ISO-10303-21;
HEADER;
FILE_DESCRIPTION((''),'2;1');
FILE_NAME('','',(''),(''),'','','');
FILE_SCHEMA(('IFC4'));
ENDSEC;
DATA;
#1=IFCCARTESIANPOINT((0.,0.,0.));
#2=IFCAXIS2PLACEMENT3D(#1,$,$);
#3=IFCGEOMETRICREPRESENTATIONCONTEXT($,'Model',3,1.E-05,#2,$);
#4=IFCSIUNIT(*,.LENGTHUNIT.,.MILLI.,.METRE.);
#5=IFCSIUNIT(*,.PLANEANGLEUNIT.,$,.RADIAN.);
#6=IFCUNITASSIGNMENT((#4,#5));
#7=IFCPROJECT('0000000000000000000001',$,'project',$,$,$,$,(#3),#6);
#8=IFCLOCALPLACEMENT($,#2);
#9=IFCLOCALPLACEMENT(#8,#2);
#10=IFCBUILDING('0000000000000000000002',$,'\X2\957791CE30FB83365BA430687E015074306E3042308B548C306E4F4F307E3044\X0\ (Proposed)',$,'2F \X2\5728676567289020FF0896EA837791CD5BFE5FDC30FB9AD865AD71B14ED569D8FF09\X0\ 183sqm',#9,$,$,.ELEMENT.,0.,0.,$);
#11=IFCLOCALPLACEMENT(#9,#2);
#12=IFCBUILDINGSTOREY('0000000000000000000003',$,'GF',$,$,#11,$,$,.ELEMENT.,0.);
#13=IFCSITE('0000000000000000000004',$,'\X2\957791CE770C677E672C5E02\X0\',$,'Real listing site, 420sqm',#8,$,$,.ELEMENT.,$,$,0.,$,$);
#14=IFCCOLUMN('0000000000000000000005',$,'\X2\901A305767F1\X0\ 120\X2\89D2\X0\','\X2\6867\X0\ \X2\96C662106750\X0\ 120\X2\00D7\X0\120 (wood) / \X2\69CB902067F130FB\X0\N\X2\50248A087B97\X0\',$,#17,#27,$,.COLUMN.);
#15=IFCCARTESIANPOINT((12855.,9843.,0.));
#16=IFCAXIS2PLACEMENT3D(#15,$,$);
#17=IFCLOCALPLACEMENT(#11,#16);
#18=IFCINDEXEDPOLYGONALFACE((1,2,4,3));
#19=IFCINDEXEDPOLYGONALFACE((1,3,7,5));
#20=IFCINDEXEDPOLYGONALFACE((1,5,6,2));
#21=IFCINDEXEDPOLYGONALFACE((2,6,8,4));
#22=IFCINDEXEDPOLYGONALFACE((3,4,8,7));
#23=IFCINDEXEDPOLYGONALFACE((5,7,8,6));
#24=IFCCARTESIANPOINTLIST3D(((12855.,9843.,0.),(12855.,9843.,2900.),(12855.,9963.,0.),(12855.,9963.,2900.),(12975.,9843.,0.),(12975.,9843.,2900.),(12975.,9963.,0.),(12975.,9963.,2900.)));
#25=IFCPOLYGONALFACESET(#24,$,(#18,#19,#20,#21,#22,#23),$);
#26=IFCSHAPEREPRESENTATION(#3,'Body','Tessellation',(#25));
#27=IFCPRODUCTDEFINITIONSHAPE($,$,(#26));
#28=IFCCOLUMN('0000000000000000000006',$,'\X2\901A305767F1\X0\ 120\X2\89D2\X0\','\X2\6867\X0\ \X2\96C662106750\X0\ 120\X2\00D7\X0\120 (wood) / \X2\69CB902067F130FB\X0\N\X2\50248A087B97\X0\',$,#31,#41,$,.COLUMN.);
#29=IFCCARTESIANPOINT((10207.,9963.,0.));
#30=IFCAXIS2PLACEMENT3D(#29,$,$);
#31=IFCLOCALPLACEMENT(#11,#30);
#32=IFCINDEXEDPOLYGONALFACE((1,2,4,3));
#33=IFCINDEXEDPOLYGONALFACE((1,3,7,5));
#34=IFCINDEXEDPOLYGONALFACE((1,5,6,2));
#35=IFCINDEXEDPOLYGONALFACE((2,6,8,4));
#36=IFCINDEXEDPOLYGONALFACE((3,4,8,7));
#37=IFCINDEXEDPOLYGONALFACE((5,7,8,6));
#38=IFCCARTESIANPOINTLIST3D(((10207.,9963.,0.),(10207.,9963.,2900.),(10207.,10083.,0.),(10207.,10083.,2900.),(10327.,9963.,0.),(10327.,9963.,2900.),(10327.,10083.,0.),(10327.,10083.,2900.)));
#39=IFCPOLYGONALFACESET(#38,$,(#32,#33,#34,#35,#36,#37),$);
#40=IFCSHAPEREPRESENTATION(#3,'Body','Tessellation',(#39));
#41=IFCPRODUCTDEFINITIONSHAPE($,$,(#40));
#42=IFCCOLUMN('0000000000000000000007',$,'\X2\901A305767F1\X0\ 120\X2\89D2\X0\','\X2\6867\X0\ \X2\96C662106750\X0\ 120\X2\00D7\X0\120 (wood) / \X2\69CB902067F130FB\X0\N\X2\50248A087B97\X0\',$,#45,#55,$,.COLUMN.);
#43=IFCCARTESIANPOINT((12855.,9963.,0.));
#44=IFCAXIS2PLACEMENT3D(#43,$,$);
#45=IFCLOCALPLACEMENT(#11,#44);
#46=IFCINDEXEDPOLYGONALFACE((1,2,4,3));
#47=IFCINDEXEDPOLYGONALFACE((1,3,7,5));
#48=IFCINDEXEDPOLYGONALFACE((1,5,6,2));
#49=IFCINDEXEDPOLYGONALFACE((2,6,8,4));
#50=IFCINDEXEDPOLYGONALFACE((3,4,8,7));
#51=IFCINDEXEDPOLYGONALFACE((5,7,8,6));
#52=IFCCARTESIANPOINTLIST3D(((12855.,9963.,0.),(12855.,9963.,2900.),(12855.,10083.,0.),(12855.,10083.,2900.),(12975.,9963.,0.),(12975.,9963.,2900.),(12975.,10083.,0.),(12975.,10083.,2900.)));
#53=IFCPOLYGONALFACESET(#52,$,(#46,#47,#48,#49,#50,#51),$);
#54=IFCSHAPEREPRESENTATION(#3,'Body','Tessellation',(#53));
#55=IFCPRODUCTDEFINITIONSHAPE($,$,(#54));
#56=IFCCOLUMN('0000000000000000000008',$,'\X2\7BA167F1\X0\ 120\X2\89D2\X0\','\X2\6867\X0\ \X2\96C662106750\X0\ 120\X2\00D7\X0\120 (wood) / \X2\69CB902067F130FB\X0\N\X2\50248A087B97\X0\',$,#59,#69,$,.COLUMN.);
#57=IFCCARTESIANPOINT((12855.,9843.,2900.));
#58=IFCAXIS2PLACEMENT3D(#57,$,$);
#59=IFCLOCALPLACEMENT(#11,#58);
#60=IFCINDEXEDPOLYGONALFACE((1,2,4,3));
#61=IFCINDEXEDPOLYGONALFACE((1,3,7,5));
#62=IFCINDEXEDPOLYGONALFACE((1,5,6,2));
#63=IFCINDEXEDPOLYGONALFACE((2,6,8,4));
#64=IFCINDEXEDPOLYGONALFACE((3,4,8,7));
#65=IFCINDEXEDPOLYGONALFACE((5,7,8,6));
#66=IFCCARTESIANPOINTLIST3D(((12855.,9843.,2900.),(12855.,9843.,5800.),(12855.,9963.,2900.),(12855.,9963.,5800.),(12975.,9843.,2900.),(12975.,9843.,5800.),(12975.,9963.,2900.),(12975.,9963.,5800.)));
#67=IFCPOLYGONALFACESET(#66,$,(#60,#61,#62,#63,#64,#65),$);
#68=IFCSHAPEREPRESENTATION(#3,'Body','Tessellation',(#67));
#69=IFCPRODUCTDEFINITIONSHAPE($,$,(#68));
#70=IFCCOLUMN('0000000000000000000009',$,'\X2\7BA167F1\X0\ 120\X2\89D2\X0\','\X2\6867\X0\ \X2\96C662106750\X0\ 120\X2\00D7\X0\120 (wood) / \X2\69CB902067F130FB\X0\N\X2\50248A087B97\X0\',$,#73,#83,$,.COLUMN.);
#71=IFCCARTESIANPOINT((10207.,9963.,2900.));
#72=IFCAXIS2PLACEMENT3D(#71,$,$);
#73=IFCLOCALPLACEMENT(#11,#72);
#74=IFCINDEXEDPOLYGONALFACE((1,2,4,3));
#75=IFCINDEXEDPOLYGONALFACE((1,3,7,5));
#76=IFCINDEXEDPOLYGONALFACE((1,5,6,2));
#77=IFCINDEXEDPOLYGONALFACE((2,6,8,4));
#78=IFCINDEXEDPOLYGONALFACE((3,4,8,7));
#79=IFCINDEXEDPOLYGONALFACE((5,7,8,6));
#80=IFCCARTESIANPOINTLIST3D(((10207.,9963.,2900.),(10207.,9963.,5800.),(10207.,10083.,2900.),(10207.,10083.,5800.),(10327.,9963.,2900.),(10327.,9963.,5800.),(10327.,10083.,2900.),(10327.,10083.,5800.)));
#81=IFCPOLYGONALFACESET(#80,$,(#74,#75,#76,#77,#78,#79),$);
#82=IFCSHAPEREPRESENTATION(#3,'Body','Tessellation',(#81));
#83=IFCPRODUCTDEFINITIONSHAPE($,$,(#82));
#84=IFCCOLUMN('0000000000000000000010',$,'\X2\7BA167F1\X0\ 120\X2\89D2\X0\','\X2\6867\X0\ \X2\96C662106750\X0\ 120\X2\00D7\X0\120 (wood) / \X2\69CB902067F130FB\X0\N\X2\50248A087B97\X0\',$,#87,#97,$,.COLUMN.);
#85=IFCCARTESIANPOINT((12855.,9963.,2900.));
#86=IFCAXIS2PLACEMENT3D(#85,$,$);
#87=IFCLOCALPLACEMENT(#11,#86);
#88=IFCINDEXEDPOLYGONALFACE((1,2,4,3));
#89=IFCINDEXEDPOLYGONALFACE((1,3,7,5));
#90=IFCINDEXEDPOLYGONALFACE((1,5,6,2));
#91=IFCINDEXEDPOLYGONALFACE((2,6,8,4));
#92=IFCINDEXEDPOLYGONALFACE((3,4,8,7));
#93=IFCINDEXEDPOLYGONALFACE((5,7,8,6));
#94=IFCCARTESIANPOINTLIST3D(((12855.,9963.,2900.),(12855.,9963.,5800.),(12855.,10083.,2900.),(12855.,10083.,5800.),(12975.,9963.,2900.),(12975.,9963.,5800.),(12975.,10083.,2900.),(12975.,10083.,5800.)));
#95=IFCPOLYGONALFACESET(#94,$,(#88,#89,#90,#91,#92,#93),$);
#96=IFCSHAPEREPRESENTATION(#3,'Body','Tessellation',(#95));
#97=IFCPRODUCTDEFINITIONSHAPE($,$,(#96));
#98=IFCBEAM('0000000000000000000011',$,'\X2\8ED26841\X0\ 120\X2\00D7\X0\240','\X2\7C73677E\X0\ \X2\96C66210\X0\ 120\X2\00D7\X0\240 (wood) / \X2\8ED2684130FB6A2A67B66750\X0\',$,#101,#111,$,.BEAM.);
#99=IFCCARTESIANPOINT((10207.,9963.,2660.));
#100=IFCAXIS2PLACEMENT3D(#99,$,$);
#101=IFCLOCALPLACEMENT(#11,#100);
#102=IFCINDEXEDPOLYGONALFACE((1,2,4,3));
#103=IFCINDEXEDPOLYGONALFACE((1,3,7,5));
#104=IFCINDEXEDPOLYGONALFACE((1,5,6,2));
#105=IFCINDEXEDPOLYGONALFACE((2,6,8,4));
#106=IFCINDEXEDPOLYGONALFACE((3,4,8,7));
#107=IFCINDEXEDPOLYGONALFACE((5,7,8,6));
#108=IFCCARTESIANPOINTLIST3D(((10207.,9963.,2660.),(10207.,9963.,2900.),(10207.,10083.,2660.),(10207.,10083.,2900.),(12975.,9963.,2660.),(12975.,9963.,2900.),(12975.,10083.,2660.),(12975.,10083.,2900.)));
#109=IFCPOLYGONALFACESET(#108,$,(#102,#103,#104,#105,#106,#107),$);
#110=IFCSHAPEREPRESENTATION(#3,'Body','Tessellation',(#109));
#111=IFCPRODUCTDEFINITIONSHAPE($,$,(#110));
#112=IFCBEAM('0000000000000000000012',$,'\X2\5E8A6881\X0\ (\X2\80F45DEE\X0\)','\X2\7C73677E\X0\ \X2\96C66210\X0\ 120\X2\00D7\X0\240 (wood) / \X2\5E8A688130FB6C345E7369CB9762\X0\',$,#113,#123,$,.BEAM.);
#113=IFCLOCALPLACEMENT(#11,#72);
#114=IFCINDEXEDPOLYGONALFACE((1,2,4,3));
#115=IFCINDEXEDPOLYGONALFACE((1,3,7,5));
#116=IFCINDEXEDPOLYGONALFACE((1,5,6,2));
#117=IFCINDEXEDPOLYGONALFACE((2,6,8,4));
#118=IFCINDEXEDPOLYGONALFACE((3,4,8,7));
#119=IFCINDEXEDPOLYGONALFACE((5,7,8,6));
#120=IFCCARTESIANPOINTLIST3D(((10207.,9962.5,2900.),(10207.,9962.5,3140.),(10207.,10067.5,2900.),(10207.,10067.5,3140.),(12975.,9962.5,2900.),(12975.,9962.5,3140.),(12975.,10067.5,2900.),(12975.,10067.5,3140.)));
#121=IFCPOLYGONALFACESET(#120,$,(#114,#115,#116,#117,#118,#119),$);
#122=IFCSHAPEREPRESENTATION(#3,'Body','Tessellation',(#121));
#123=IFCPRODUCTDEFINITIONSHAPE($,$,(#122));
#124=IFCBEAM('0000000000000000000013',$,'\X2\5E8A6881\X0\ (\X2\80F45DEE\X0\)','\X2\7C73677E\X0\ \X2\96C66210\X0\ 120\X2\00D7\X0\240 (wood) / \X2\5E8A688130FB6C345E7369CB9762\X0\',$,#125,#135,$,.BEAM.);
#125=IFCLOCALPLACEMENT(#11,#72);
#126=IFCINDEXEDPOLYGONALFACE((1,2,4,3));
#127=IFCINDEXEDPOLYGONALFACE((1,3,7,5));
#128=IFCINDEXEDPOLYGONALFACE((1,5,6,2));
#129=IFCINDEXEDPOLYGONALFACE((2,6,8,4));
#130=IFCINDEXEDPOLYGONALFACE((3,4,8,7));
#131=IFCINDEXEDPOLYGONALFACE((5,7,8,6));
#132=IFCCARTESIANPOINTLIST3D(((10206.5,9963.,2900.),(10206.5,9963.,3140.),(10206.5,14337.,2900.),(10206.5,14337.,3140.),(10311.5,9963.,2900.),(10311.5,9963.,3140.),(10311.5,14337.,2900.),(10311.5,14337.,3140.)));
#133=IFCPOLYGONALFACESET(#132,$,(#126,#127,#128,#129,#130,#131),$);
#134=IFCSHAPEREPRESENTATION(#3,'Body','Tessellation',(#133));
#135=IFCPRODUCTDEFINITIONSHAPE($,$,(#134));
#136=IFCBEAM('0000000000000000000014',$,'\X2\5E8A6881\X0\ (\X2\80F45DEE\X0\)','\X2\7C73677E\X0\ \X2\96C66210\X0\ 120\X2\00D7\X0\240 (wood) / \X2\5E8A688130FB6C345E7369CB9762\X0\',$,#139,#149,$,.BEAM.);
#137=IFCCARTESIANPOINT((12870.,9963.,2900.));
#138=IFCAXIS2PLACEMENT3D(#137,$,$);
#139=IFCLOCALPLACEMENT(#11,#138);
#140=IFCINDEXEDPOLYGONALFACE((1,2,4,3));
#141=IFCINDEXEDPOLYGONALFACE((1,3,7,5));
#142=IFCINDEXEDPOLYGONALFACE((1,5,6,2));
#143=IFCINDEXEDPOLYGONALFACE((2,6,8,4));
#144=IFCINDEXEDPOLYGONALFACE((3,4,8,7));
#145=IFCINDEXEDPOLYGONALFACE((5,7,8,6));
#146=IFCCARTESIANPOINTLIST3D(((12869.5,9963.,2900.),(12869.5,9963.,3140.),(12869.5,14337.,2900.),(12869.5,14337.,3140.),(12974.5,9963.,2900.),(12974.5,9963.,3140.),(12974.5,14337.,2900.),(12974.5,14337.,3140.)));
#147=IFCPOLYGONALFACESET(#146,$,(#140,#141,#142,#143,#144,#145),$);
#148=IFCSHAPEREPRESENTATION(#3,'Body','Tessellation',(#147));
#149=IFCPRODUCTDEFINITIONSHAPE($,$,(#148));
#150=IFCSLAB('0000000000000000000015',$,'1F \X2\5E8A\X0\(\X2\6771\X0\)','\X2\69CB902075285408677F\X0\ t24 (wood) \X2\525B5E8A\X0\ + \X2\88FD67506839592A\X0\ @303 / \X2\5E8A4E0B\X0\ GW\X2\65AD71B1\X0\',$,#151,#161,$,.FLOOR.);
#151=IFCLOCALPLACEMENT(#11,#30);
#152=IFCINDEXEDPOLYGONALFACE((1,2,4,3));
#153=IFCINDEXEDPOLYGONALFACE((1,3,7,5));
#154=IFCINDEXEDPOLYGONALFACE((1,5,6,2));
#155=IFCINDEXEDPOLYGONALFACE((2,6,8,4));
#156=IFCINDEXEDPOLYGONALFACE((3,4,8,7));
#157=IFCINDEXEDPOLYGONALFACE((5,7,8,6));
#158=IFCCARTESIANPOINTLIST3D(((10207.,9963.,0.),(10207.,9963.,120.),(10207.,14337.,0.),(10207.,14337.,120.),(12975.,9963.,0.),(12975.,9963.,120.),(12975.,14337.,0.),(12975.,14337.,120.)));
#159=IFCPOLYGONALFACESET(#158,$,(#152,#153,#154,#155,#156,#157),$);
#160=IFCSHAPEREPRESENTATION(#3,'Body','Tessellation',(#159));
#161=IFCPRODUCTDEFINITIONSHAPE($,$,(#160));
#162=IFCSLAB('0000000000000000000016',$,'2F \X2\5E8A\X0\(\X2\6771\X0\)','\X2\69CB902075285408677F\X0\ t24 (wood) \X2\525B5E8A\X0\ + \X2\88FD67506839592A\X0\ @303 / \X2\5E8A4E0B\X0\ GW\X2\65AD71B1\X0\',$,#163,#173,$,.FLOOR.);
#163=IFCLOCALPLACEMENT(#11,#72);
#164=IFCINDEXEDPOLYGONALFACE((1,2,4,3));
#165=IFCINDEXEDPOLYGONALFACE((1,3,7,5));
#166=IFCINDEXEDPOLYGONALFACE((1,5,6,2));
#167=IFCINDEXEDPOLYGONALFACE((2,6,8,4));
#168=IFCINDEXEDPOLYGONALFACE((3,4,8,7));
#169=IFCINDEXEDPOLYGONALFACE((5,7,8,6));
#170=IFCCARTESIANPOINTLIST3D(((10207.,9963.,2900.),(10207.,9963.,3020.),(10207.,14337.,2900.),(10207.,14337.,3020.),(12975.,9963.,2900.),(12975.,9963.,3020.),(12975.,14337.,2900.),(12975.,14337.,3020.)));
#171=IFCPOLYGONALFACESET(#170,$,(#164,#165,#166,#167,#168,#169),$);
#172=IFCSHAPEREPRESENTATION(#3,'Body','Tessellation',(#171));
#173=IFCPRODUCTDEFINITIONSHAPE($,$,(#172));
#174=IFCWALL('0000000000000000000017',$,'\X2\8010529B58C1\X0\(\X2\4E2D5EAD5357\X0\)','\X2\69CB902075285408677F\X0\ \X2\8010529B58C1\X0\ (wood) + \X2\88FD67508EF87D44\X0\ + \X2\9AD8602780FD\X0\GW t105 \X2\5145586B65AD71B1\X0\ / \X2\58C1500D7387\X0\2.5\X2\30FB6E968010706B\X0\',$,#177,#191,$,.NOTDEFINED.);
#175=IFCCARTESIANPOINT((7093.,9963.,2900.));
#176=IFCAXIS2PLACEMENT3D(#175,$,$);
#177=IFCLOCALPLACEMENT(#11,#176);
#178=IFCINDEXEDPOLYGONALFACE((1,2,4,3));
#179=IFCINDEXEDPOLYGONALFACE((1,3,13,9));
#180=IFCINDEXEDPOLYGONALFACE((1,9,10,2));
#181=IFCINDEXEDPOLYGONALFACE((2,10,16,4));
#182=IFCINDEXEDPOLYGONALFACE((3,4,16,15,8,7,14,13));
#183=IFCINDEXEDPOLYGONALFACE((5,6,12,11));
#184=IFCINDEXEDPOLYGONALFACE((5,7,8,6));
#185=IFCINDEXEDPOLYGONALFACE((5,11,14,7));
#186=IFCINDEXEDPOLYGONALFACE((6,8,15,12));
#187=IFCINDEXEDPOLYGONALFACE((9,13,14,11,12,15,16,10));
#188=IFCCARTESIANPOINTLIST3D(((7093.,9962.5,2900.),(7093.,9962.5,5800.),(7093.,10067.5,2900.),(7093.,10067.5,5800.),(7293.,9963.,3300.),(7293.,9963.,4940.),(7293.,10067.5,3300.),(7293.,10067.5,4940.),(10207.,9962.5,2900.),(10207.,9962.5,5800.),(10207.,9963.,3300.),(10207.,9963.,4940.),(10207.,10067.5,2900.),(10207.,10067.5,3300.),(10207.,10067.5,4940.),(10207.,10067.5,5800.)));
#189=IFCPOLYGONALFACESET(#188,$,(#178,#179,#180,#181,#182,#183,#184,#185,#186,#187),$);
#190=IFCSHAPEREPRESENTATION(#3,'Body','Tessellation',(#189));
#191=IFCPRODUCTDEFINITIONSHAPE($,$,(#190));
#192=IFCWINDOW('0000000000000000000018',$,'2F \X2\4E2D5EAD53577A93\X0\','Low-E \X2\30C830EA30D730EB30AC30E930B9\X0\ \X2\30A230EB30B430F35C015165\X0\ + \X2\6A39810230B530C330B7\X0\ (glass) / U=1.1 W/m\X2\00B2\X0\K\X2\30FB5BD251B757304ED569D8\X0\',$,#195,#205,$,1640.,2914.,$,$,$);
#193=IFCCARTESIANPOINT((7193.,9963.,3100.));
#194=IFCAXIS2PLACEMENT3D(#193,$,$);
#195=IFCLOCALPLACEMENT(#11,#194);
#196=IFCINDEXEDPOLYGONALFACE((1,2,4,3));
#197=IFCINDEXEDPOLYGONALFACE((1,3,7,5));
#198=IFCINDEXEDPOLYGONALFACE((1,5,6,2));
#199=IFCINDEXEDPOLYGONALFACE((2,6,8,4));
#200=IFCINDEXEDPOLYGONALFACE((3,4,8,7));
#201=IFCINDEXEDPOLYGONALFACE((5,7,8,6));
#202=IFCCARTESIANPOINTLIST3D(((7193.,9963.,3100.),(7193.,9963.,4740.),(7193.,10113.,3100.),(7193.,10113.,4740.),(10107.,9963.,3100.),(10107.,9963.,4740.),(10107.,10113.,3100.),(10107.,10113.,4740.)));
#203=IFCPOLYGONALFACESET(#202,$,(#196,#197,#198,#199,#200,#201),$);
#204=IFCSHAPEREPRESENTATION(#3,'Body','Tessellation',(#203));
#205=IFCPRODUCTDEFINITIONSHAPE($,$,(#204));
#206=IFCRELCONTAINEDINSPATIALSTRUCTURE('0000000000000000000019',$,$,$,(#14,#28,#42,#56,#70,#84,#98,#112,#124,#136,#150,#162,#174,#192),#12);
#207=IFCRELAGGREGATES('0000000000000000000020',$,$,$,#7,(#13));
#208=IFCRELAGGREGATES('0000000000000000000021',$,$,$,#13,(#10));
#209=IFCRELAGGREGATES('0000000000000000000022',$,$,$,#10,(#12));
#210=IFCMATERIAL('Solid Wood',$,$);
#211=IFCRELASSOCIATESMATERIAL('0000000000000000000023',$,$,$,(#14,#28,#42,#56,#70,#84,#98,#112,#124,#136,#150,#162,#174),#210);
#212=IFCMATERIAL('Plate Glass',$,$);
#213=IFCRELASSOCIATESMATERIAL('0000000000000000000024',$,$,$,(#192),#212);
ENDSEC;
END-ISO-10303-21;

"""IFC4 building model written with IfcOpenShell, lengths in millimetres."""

from ifc_helpers import new_model, si_unit, frame, frame_2d, origin, place, context, project, spatial, rectangle, extrude, material, element, fill, save


model = new_model("IFC4")

# Units and contexts
model_context = context("Model", 3, precision=1e-05, world=origin())
ifc_project = project(units=[si_unit("LENGTHUNIT", "METRE", prefix="MILLI"), si_unit("PLANEANGLEUNIT", "RADIAN")], contexts=[model_context])

# Site, building, storey
site_placement = place(None, origin())
site = spatial("IfcSite", under=ifc_project, at=site_placement, Name="長野県松本市", ObjectType="Real listing site, 420sqm", CompositionType="ELEMENT", RefElevation=0.0)
building_placement = place(site_placement, origin())
building = spatial("IfcBuilding", under=site, at=building_placement, Name="長野・茶室と縁側のある和の住まい (Proposed)", ObjectType="2F 在来木造（雪荷重対応・高断熱仕様） 183sqm", CompositionType="ELEMENT", ElevationOfRefHeight=0.0, ElevationOfTerrain=0.0)
storey_placement = place(building_placement, origin())
storey = spatial("IfcBuildingStorey", under=building, at=storey_placement, Name="GF", CompositionType="ELEMENT", Elevation=0.0)

# Columns
ifc_material_1 = material(Name="Solid Wood")
column_1_placement = place(storey_placement, frame((12855.0, 9843.0, 0.0)))
element("IfcColumn", 1, at=column_1_placement, inside=storey, material=ifc_material_1, Name="通し柱 120角", Description="桧 集成材 120×120 (wood) / 構造柱・N値計算", PredefinedType="COLUMN", context=model_context, shape_type="SweptSolid", body=[
    extrude(rectangle(XDim=120.0, YDim=120.0, at=frame_2d((60.0, 60.0))), frame((12855.0, 9843.0, 0.0)), (0.0, 0.0, 1.0), 2900.0),
])
column_2_placement = place(storey_placement, frame((10207.0, 9963.0, 0.0)))
element("IfcColumn", 2, at=column_2_placement, inside=storey, material=ifc_material_1, Name="通し柱 120角", Description="桧 集成材 120×120 (wood) / 構造柱・N値計算", PredefinedType="COLUMN", context=model_context, shape_type="SweptSolid", body=[
    extrude(rectangle(XDim=120.0, YDim=120.0, at=frame_2d((60.0, 60.0))), frame((10207.0, 9963.0, 0.0)), (0.0, 0.0, 1.0), 2900.0),
])
column_3_placement = place(storey_placement, frame((12855.0, 9963.0, 0.0)))
element("IfcColumn", 3, at=column_3_placement, inside=storey, material=ifc_material_1, Name="通し柱 120角", Description="桧 集成材 120×120 (wood) / 構造柱・N値計算", PredefinedType="COLUMN", context=model_context, shape_type="SweptSolid", body=[
    extrude(rectangle(XDim=120.0, YDim=120.0, at=frame_2d((60.0, 60.0))), frame((12855.0, 9963.0, 0.0)), (0.0, 0.0, 1.0), 2900.0),
])
column_4_placement = place(storey_placement, frame((12855.0, 9843.0, 2900.0)))
element("IfcColumn", 4, at=column_4_placement, inside=storey, material=ifc_material_1, Name="管柱 120角", Description="桧 集成材 120×120 (wood) / 構造柱・N値計算", PredefinedType="COLUMN", context=model_context, shape_type="SweptSolid", body=[
    extrude(rectangle(XDim=120.0, YDim=120.0, at=frame_2d((60.0, 60.0))), frame((12855.0, 9843.0, 2900.0)), (0.0, 0.0, 1.0), 2900.0),
])
column_5_placement = place(storey_placement, frame((10207.0, 9963.0, 2900.0)))
element("IfcColumn", 5, at=column_5_placement, inside=storey, material=ifc_material_1, Name="管柱 120角", Description="桧 集成材 120×120 (wood) / 構造柱・N値計算", PredefinedType="COLUMN", context=model_context, shape_type="SweptSolid", body=[
    extrude(rectangle(XDim=120.0, YDim=120.0, at=frame_2d((60.0, 60.0))), frame((10207.0, 9963.0, 2900.0)), (0.0, 0.0, 1.0), 2900.0),
])
column_6_placement = place(storey_placement, frame((12855.0, 9963.0, 2900.0)))
element("IfcColumn", 6, at=column_6_placement, inside=storey, material=ifc_material_1, Name="管柱 120角", Description="桧 集成材 120×120 (wood) / 構造柱・N値計算", PredefinedType="COLUMN", context=model_context, shape_type="SweptSolid", body=[
    extrude(rectangle(XDim=120.0, YDim=120.0, at=frame_2d((60.0, 60.0))), frame((12855.0, 9963.0, 2900.0)), (0.0, 0.0, 1.0), 2900.0),
])

# Beams
beam_1_placement = place(storey_placement, frame((10207.0, 9963.0, 2660.0)))
element("IfcBeam", 7, at=beam_1_placement, inside=storey, material=ifc_material_1, Name="軒桁 120×240", Description="米松 集成 120×240 (wood) / 軒桁・横架材", PredefinedType="BEAM", context=model_context, shape_type="SweptSolid", body=[
    extrude(rectangle(XDim=2768.0, YDim=120.0, at=frame_2d((1384.0, 60.0))), frame((10207.0, 9963.0, 2660.0)), (0.0, 0.0, 1.0), 240.0),
])
beam_2_placement = place(storey_placement, frame((10207.0, 9963.0, 2900.0)))
element("IfcBeam", 8, at=beam_2_placement, inside=storey, material=ifc_material_1, Name="床梁 (胴差)", Description="米松 集成 120×240 (wood) / 床梁・水平構面", PredefinedType="BEAM", context=model_context, shape_type="SweptSolid", body=[
    extrude(rectangle(XDim=2768.0, YDim=105.0, at=frame_2d((1384.0, 52.0))), frame((10207.0, 9963.0, 2900.0)), (0.0, 0.0, 1.0), 240.0),
])
beam_3_placement = place(storey_placement, frame((10207.0, 9963.0, 2900.0)))
element("IfcBeam", 9, at=beam_3_placement, inside=storey, material=ifc_material_1, Name="床梁 (胴差)", Description="米松 集成 120×240 (wood) / 床梁・水平構面", PredefinedType="BEAM", context=model_context, shape_type="SweptSolid", body=[
    extrude(rectangle(XDim=105.0, YDim=4374.0, at=frame_2d((52.0, 2187.0))), frame((10207.0, 9963.0, 2900.0)), (0.0, 0.0, 1.0), 240.0),
])
beam_4_placement = place(storey_placement, frame((12870.0, 9963.0, 2900.0)))
element("IfcBeam", 10, at=beam_4_placement, inside=storey, material=ifc_material_1, Name="床梁 (胴差)", Description="米松 集成 120×240 (wood) / 床梁・水平構面", PredefinedType="BEAM", context=model_context, shape_type="SweptSolid", body=[
    extrude(rectangle(XDim=105.0, YDim=4374.0, at=frame_2d((52.0, 2187.0))), frame((12870.0, 9963.0, 2900.0)), (0.0, 0.0, 1.0), 240.0),
])

# Slabs
slab_1_placement = place(storey_placement, frame((10207.0, 9963.0, 0.0)))
element("IfcSlab", 11, at=slab_1_placement, inside=storey, material=ifc_material_1, Name="1F 床(東)", Description="構造用合板 t24 (wood) 剛床 + 製材根太 @303 / 床下 GW断熱", PredefinedType="FLOOR", context=model_context, shape_type="SweptSolid", body=[
    extrude(rectangle(XDim=2768.0, YDim=4374.0, at=frame_2d((1384.0, 2187.0))), frame((10207.0, 9963.0, 0.0)), (0.0, 0.0, 1.0), 120.0),
])
slab_2_placement = place(storey_placement, frame((10207.0, 9963.0, 2900.0)))
element("IfcSlab", 12, at=slab_2_placement, inside=storey, material=ifc_material_1, Name="2F 床(東)", Description="構造用合板 t24 (wood) 剛床 + 製材根太 @303 / 床下 GW断熱", PredefinedType="FLOOR", context=model_context, shape_type="SweptSolid", body=[
    extrude(rectangle(XDim=2768.0, YDim=4374.0, at=frame_2d((1384.0, 2187.0))), frame((10207.0, 9963.0, 2900.0)), (0.0, 0.0, 1.0), 120.0),
])

# Wall, opening, window
wall_1_placement = place(storey_placement, frame((7093.0, 9963.0, 2900.0)))
wall_1 = element("IfcWall", 13, at=wall_1_placement, inside=storey, material=ifc_material_1, Name="耐力壁(中庭南)", Description="構造用合板 耐力壁 (wood) + 製材軸組 + 高性能GW t105 充填断熱 / 壁倍率2.5・準耐火", PredefinedType="NOTDEFINED", context=model_context, shape_type="SweptSolid", body=[
    extrude(rectangle(XDim=3114.0, YDim=105.0, at=frame_2d((1557.0, 52.0))), frame((7093.0, 9963.0, 2900.0)), (0.0, 0.0, 1.0), 2900.0),
])
opening_placement = place(storey_placement, frame((7193.0, 9963.0, 3100.0)))
opening = element("IfcOpeningElement", 14, at=opening_placement, cuts=wall_1, PredefinedType="NOTDEFINED", context=model_context, shape_type="SweptSolid", body=[
    extrude(rectangle(XDim=2914.0, YDim=150.0, at=frame_2d((1457.0, 75.0))), frame((7193.0, 9963.0, 3100.0)), (0.0, 0.0, 1.0), 1640.0),
])
ifc_material_2 = material(Name="Plate Glass")
window_placement = place(storey_placement, frame((7193.0, 9963.0, 3100.0)))
window = element("IfcWindow", 15, at=window_placement, inside=storey, material=ifc_material_2, Name="2F 中庭南窓", Description="Low-E トリプルガラス アルゴン封入 + 樹脂サッシ (glass) / U=1.1 W/m²K・寒冷地仕様", OverallHeight=1640.0, OverallWidth=2914.0, context=model_context, shape_type="SweptSolid", body=[
    extrude(rectangle(XDim=2914.0, YDim=150.0, at=frame_2d((1457.0, 75.0))), frame((7193.0, 9963.0, 3100.0)), (0.0, 0.0, 1.0), 1640.0),
])
fill(opening, window)

save(model, "model.ifc")
